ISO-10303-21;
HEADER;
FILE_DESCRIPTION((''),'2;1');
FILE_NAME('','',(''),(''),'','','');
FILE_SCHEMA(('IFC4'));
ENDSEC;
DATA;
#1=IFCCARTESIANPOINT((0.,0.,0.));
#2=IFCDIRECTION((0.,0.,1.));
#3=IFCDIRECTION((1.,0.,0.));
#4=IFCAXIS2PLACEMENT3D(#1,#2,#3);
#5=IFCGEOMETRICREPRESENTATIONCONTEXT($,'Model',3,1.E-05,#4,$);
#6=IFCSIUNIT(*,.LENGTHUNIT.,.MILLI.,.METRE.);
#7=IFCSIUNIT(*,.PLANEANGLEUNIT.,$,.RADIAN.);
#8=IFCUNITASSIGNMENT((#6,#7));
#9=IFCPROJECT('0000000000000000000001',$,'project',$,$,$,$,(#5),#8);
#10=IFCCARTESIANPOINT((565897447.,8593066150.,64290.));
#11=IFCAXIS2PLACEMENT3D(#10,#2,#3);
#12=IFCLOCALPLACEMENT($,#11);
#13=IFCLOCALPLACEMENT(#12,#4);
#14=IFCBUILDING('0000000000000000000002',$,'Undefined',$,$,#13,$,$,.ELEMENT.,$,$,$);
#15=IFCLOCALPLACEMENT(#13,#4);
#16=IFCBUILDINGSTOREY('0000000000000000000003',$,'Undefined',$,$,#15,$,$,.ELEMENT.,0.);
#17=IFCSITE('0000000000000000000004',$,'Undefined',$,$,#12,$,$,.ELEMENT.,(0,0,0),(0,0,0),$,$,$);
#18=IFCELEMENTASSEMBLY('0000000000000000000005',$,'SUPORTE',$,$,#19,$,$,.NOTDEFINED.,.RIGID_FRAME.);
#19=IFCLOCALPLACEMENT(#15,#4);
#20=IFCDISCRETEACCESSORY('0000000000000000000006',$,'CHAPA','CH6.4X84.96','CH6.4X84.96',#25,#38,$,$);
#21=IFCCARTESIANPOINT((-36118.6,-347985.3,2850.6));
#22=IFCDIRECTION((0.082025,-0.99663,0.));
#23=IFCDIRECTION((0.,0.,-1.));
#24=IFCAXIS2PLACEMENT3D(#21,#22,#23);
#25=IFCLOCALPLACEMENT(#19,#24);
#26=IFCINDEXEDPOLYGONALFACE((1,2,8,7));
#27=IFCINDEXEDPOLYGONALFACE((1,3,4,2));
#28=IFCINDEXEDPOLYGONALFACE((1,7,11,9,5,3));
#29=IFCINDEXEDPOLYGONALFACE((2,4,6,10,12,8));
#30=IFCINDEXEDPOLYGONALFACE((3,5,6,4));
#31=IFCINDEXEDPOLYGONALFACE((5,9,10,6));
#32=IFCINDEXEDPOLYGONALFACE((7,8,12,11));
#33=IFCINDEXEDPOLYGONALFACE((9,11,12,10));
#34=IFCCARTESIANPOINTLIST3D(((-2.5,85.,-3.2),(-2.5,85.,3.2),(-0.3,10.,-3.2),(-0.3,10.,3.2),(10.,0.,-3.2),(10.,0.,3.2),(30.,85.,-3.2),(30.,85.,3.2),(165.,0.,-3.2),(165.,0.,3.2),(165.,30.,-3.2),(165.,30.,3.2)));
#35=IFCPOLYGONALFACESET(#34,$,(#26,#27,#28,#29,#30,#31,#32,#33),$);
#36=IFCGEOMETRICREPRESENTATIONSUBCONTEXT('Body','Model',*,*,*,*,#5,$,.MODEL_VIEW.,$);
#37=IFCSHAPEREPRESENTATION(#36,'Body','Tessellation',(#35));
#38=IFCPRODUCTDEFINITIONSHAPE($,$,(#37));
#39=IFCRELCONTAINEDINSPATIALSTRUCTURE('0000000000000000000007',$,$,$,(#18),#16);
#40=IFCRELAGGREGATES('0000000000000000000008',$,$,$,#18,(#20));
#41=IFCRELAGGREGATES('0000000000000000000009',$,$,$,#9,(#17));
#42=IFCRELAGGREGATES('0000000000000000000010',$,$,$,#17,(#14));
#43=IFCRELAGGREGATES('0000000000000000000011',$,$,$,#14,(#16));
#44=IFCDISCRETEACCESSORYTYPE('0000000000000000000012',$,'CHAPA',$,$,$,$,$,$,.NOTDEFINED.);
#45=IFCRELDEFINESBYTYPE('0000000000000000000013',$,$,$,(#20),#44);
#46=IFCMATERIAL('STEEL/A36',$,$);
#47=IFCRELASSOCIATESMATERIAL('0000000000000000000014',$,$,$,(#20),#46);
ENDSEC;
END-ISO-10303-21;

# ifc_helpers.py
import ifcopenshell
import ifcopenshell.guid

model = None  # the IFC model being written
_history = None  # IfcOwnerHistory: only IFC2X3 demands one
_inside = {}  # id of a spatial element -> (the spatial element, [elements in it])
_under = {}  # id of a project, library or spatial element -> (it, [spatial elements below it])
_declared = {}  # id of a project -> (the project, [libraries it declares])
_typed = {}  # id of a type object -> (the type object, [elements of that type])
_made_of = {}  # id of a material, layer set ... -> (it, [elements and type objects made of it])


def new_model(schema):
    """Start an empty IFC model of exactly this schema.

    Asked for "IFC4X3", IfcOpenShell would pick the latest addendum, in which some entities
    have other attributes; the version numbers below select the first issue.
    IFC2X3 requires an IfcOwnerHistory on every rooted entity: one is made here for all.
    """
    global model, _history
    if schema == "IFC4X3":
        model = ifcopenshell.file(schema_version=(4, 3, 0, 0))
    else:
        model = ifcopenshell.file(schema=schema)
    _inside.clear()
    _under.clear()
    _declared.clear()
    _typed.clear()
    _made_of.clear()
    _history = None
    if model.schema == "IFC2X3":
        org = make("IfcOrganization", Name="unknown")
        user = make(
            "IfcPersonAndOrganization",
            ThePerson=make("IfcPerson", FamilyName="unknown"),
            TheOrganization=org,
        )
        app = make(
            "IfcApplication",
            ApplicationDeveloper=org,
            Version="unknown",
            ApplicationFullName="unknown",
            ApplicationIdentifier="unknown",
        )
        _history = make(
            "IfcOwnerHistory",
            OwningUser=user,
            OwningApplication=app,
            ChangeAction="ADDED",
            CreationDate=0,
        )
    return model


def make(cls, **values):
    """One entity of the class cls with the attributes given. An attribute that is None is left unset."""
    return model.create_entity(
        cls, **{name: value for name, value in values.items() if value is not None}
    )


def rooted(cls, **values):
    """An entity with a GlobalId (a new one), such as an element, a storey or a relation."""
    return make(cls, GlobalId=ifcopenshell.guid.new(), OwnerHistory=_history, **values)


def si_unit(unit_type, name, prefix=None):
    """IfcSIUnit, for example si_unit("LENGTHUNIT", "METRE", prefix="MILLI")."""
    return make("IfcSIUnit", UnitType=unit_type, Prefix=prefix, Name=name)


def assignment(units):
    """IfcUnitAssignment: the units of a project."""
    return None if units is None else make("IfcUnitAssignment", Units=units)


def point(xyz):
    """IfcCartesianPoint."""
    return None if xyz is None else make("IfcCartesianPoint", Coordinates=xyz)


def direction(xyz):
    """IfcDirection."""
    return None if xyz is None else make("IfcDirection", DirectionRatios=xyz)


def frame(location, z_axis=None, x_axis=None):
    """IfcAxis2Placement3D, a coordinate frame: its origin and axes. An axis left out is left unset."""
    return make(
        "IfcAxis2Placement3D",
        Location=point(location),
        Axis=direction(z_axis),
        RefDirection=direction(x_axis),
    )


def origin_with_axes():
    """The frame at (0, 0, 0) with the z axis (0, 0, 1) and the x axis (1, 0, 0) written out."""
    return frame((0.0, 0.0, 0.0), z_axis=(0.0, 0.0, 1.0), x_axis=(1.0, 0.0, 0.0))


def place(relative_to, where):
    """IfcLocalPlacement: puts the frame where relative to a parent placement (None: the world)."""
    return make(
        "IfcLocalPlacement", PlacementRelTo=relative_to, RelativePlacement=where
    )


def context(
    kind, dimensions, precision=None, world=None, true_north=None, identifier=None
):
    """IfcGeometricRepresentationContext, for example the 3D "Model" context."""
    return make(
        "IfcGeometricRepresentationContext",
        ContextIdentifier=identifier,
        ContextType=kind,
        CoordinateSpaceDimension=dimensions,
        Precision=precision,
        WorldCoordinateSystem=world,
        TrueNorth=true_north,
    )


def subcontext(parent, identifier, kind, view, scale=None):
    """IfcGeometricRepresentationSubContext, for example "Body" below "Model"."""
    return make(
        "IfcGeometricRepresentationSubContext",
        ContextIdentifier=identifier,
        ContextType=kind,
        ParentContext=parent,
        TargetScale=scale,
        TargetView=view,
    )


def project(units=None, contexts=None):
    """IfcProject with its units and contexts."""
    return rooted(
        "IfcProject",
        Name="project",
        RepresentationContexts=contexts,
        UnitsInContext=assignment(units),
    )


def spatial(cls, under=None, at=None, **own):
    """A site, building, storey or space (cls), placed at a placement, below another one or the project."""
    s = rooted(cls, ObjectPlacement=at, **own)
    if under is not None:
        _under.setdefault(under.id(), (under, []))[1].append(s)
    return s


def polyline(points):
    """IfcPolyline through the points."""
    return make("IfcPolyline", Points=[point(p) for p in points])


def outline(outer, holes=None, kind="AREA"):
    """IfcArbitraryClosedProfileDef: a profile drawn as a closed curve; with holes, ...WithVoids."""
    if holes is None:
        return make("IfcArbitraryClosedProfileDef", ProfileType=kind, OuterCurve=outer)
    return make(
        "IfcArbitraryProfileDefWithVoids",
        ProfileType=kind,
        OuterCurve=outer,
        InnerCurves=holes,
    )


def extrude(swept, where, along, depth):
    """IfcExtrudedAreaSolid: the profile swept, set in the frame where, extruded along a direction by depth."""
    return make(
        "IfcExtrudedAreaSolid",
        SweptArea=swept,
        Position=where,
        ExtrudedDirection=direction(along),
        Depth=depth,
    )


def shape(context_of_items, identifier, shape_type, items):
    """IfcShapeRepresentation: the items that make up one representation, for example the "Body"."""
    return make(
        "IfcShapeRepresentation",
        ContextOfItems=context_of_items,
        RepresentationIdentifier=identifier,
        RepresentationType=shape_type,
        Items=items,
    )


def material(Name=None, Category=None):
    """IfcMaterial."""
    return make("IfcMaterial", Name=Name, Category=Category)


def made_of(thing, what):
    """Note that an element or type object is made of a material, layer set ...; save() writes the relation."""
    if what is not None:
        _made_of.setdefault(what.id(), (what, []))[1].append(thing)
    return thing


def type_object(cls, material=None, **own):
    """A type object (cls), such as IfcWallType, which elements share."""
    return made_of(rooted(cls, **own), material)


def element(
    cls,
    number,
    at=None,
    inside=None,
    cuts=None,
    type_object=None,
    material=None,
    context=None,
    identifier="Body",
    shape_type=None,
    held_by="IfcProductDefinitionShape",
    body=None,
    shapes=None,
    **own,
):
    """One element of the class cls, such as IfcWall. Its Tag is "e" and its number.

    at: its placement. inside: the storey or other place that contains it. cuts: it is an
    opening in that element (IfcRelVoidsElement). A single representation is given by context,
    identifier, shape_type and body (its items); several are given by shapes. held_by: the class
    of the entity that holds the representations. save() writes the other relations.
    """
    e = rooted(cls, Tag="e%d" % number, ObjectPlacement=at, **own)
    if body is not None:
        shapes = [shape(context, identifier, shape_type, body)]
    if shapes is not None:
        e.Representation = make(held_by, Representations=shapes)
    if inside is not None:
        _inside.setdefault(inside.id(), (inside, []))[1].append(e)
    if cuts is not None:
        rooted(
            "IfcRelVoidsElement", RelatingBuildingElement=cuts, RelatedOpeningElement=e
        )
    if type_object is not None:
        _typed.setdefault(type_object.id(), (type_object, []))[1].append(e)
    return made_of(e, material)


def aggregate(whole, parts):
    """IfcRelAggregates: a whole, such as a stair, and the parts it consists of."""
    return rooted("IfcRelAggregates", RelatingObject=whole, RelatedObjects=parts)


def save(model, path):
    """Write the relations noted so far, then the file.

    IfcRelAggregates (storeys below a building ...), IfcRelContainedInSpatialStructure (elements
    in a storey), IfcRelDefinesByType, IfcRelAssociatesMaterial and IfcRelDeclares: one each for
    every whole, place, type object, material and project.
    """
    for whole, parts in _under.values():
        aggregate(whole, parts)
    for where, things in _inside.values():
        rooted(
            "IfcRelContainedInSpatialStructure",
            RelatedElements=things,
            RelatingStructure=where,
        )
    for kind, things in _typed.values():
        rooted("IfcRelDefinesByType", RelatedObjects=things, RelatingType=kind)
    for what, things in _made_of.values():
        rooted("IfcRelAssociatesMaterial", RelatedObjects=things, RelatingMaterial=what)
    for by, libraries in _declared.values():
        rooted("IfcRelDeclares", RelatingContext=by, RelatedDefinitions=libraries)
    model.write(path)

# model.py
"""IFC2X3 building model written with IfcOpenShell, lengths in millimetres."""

from ifc_helpers import new_model, si_unit, frame, origin_with_axes, place, context, subcontext, project, spatial, polyline, outline, extrude, material, type_object, element, aggregate, save


model = new_model("IFC2X3")

# Units and contexts
model_context = context("Model", 3, precision=1e-05, world=origin_with_axes())
body_context = subcontext(model_context, "Body", "Model", "MODEL_VIEW")
ifc_project = project(units=[si_unit("LENGTHUNIT", "METRE", prefix="MILLI"), si_unit("PLANEANGLEUNIT", "RADIAN")], contexts=[model_context])

# Site, building, storey
site_placement = place(None, frame((565897447.0, 8593066150.0, 64290.0), z_axis=(0.0, 0.0, 1.0), x_axis=(1.0, 0.0, 0.0)))
site = spatial("IfcSite", under=ifc_project, at=site_placement, Name="Undefined", CompositionType="ELEMENT", RefLatitude=(0, 0, 0), RefLongitude=(0, 0, 0))
building_placement = place(site_placement, origin_with_axes())
building = spatial("IfcBuilding", under=site, at=building_placement, Name="Undefined", CompositionType="ELEMENT")
storey_placement = place(building_placement, origin_with_axes())
storey = spatial("IfcBuildingStorey", under=building, at=storey_placement, Name="Undefined", CompositionType="ELEMENT", Elevation=0.0)

# Shared definitions
ifc_material_1 = material(Name="STEEL/A36")

# Shared definitions
discrete_accessory_type_1 = type_object("IfcDiscreteAccessoryType", Name="CHAPA")

# Element assembly, discrete accessory
assembly_1_placement = place(storey_placement, origin_with_axes())
assembly_1 = element("IfcElementAssembly", 1, at=assembly_1_placement, inside=storey, Name="SUPORTE", AssemblyPlace="NOTDEFINED", PredefinedType="RIGID_FRAME")
discrete_accessory_1_placement = place(assembly_1_placement, frame((-36118.6, -347985.3, 2850.6), z_axis=(0.082025, -0.99663, 0.0), x_axis=(0.0, 0.0, -1.0)))
discrete_accessory_1 = element("IfcDiscreteAccessory", 2, at=discrete_accessory_1_placement, type_object=discrete_accessory_type_1, material=ifc_material_1, Name="CHAPA", Description="CH6.4X84.96", ObjectType="CH6.4X84.96", context=body_context, shape_type="SweptSolid", body=[
    extrude(outline(polyline([(-0.3, 10.0), (10.0, 0.0), (165.0, 0.0), (165.0, 30.0), (30.0, 85.0), (-2.5, 85.0), (-0.3, 10.0)])), frame((0.0, 0.0, -3.2), z_axis=(0.0, 0.0, 1.0), x_axis=(1.0, 0.0, 0.0)), (0.0, 0.0, 1.0), 6.4),
])
aggregate(assembly_1, [discrete_accessory_1])

save(model, "model.ifc")
